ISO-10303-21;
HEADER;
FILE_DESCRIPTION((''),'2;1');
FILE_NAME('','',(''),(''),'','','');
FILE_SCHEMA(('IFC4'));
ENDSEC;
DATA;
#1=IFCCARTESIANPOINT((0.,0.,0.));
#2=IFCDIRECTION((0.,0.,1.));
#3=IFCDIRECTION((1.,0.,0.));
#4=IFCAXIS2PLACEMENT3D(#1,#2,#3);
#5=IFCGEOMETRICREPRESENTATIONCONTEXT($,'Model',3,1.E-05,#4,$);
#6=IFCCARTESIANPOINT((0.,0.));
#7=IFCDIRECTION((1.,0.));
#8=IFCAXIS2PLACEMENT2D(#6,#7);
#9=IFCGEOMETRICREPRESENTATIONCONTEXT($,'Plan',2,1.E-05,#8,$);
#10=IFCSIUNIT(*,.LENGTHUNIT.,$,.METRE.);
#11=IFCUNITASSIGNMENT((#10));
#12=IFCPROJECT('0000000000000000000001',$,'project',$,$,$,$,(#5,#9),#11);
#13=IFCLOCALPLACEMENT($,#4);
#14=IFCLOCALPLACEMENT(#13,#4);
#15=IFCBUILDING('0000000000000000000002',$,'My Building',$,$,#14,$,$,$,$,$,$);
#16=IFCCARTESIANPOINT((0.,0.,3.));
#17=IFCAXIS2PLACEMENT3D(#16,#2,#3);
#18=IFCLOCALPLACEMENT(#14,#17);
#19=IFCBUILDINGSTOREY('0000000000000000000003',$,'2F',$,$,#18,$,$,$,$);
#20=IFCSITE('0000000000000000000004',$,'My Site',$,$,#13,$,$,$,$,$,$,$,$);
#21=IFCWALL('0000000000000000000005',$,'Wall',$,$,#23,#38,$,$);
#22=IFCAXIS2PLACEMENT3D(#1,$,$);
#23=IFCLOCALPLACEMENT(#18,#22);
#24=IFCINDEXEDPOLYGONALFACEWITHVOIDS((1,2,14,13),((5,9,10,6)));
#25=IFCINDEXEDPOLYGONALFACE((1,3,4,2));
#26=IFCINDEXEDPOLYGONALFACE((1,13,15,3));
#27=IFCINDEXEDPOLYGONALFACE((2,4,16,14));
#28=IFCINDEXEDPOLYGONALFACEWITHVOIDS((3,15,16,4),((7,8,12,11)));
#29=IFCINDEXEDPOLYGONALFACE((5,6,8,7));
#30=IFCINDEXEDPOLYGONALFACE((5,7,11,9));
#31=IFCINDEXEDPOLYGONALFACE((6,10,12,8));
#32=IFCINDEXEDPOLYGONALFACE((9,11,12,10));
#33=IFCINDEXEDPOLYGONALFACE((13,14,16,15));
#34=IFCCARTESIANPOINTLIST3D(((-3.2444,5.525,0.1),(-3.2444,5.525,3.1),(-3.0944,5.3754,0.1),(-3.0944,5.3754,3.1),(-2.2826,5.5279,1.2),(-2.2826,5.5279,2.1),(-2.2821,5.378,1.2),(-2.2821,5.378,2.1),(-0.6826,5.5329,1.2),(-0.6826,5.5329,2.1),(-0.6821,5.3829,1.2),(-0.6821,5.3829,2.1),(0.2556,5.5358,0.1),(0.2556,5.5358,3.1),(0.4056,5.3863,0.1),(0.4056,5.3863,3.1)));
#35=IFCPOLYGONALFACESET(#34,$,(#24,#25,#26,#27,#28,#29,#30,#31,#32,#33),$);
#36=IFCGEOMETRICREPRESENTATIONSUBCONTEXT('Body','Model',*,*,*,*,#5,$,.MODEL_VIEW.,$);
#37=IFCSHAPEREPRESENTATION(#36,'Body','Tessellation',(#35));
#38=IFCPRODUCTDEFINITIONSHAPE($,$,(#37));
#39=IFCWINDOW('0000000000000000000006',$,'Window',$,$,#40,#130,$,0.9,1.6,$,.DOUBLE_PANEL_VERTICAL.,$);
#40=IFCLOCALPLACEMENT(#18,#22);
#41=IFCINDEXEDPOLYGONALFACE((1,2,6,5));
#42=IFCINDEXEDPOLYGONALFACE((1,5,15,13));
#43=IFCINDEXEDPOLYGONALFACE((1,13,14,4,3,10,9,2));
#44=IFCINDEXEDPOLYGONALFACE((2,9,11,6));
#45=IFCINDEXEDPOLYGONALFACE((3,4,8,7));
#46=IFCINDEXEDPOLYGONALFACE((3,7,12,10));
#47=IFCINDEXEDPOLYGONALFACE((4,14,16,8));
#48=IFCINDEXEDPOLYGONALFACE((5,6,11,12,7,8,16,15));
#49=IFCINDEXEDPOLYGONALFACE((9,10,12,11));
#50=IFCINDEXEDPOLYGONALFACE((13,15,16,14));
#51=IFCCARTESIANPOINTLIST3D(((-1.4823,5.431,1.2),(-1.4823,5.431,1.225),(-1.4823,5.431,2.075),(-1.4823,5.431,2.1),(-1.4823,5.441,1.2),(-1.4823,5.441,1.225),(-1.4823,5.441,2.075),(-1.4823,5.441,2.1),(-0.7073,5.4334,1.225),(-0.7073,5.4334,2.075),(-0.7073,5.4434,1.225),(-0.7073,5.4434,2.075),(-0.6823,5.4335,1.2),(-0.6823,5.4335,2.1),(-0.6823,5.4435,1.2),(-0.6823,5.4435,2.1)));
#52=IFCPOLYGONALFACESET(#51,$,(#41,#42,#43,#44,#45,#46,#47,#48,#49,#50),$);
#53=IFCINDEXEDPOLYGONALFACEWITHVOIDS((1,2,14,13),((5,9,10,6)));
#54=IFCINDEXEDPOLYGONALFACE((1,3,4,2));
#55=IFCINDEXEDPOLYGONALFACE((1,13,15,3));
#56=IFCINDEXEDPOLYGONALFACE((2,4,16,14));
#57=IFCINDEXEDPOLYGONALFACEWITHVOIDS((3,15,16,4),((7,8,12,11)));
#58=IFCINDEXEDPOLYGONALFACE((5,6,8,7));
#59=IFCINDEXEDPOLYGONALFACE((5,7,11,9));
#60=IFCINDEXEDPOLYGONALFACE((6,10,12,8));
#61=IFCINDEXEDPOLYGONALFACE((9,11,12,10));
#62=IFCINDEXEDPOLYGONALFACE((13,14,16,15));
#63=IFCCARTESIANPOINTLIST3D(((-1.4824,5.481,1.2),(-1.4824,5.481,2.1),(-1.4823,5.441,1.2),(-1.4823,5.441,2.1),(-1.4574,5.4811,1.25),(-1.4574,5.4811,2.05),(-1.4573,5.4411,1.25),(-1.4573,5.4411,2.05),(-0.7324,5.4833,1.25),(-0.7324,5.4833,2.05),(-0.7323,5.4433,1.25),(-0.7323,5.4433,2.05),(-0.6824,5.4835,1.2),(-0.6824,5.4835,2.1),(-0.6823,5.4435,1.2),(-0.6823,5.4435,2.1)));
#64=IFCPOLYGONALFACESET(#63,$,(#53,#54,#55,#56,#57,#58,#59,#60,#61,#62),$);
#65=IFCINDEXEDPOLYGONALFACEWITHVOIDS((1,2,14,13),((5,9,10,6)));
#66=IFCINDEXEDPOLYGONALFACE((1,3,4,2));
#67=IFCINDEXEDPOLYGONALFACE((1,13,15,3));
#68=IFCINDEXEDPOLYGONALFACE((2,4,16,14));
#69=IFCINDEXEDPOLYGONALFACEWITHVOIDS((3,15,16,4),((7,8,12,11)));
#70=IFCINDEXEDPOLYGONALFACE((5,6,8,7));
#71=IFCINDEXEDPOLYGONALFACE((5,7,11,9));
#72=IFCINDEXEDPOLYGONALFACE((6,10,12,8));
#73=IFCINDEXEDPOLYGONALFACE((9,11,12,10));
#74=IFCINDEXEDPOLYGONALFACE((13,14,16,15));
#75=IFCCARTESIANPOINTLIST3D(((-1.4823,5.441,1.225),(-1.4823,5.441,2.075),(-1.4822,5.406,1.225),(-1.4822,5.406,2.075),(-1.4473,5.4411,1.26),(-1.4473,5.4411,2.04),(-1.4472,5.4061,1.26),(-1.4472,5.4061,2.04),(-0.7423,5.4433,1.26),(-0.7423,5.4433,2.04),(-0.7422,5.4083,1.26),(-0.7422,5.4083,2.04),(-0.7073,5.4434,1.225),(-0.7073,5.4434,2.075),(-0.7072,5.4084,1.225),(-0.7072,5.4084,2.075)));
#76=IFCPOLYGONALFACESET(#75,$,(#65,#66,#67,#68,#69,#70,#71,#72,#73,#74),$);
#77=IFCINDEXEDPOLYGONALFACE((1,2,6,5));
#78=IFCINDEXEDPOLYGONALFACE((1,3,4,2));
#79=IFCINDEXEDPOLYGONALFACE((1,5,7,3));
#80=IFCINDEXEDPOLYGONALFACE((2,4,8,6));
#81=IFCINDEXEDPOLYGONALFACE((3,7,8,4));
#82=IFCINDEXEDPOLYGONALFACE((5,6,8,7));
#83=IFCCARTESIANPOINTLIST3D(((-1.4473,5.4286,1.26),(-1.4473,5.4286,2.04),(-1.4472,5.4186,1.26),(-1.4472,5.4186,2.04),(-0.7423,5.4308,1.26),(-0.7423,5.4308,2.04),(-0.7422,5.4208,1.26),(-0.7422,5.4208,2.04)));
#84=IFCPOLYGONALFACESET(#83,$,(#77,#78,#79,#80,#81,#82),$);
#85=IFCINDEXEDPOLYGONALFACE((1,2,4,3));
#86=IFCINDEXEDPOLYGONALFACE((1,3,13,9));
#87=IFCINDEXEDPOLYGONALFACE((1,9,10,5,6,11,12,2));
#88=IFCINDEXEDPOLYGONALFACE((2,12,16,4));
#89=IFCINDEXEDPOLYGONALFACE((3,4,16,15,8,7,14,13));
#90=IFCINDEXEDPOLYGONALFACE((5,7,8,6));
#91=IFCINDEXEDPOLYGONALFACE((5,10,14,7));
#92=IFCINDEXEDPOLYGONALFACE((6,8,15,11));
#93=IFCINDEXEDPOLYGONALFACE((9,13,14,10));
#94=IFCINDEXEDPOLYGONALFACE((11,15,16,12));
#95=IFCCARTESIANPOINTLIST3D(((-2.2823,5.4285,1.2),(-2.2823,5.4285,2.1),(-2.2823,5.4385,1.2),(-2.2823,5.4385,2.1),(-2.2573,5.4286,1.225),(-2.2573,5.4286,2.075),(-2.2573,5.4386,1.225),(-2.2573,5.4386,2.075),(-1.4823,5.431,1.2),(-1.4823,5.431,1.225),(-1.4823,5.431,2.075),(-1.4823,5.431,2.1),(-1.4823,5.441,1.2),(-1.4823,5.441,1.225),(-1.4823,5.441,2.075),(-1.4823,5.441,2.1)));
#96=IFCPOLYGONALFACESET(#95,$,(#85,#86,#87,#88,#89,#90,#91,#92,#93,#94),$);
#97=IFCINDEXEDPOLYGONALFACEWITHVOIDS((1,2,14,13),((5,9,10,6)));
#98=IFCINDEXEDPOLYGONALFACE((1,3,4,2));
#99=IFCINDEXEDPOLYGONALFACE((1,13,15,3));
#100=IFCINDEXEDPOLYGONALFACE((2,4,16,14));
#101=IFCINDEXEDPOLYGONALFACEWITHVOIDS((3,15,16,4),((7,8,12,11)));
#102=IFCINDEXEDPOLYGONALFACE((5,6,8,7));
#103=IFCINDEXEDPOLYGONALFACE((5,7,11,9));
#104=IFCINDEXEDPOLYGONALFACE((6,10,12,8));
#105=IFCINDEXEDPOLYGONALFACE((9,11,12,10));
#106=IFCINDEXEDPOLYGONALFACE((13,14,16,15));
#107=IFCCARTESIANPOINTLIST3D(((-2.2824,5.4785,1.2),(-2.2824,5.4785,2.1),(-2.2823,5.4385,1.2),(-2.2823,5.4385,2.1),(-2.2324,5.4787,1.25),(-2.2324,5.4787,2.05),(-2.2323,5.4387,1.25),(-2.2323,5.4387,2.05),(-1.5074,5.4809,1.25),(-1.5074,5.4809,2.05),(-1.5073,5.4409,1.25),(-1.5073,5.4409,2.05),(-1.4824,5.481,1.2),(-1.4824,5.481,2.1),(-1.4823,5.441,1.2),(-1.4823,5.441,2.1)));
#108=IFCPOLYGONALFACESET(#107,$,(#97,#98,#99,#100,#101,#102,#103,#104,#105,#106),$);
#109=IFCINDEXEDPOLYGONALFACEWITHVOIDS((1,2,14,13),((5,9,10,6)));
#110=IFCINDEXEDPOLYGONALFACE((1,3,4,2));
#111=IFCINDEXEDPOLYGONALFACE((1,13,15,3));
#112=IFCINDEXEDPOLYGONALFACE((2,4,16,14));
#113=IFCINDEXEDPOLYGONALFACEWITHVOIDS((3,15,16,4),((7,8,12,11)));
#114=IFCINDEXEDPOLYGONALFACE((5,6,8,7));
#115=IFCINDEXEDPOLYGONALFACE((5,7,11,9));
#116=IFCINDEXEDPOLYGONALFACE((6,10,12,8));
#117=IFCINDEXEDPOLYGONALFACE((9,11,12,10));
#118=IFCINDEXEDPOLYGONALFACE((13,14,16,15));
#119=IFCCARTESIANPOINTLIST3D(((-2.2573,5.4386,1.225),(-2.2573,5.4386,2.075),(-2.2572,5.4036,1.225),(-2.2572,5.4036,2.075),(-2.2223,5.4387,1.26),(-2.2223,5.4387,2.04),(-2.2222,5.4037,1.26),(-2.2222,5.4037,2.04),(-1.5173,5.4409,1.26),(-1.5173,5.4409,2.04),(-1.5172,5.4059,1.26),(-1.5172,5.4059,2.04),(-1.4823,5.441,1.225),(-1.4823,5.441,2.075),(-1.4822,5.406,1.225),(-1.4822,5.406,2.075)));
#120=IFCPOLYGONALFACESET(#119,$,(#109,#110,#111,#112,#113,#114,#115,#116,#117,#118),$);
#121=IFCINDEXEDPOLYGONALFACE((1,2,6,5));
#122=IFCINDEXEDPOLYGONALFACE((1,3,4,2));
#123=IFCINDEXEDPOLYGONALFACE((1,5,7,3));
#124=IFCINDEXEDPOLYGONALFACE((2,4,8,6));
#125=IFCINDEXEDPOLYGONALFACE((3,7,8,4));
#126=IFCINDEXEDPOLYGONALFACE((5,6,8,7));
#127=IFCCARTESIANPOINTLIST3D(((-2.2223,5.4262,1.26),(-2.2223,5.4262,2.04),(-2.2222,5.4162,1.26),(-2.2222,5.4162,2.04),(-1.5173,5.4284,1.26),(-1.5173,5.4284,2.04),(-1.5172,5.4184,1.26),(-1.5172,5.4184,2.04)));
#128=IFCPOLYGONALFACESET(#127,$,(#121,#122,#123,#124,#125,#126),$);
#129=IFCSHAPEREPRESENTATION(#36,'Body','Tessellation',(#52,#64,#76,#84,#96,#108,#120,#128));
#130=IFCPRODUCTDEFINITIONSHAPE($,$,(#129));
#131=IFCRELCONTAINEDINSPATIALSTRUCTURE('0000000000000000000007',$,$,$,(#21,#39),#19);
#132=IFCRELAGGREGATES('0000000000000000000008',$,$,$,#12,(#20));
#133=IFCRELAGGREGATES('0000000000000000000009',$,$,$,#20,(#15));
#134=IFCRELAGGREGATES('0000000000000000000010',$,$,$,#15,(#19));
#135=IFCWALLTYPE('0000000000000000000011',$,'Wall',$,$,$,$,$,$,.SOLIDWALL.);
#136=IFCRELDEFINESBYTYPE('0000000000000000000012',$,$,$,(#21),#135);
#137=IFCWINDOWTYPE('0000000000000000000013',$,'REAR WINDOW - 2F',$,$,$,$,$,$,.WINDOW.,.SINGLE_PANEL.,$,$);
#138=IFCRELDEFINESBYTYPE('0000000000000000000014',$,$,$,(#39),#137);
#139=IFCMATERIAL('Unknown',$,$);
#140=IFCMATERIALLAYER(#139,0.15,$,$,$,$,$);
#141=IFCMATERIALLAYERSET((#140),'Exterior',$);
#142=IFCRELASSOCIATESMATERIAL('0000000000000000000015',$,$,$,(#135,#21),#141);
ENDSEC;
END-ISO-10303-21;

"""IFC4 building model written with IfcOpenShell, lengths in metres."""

from ifc_helpers import new_model, entity, si_unit, frame, origin_with_axes, origin_2d_with_axis, place, context, subcontext, project, spatial, line, indexed_curve, outline, extrude, shape, source, transform, mapped, material, layer, layer_set, layer_usage, type_object, type_shapes, element, fill, save


model = new_model("IFC4")

# Units and contexts
model_context = context("Model", 3, precision=1e-05, world=origin_with_axes())
plan_context = context("Plan", 2, precision=1e-05, world=origin_2d_with_axis())
body_context_1 = subcontext(model_context, "Body", "Model", "MODEL_VIEW")
body_context_2 = subcontext(plan_context, "Body", "Plan", "PLAN_VIEW")
ifc_project = project(units=[si_unit("LENGTHUNIT", "METRE")], contexts=[model_context, plan_context])

# Site, building, storey
site_placement = place(None, origin_with_axes())
site = spatial("IfcSite", under=ifc_project, at=site_placement, Name="My Site")
building_placement = place(site_placement, origin_with_axes())
building = spatial("IfcBuilding", under=site, at=building_placement, Name="My Building")
storey_placement = place(building_placement, frame((0.0, 0.0, 3.0), z_axis=(0.0, 0.0, 1.0), x_axis=(1.0, 0.0, 0.0)))
storey = spatial("IfcBuildingStorey", under=building, at=storey_placement, Name="2F")

# Shared definitions
ifc_material = material(Name="Unknown")

# Shared definitions
ifc_layer_1 = layer(ifc_material, 0.15)
ifc_layer_set_1 = layer_set([ifc_layer_1], Name="Exterior")
wall_type_1 = type_object("IfcWallType", Name="Wall", PredefinedType="SOLIDWALL", material=ifc_layer_set_1)

# Wall, opening, window
ifc_layer_usage_1 = layer_usage(ifc_layer_set_1, "AXIS2", "POSITIVE", 0.0)
wall_1_placement = place(storey_placement, frame((0.2556, 5.5358, 0.1), z_axis=(0.0, 0.0, 1.0), x_axis=(-0.999995, -0.003097, 0.0)))
wall_1 = element("IfcWall", 1, at=wall_1_placement, inside=storey, type_object=wall_type_1, material=ifc_layer_usage_1, Name="Wall", context=body_context_1, shape_type="SweptSolid", body=[
    extrude(outline(indexed_curve([(0.0, 0.0), (-0.1495, 0.15), (3.3505, 0.15), (3.5, 0.0)], segments=[line(1, 2, 3, 4, 1)])), origin_with_axes(), (0.0, 0.0, 1.0), 3.0),
])
shared_shape_1 = source(origin_with_axes(), body_context_1, "Body", "SweptSolid", [
    extrude(outline(indexed_curve([(0.0, 0.0), (1.6, 0.0), (1.6, 0.9), (0.0, 0.9)], segments=[line(1, 2, 3, 4, 1)])), frame((0.0, -0.6, 0.0), z_axis=(0.0, -1.0, 0.0), x_axis=(1.0, 0.0, 0.0)), (0.0, 0.0, -1.0), 1.2),
])
opening_1_placement = place(wall_1_placement, frame((0.9382, -0.0006, 1.1), z_axis=(0.0, 0.0, 1.0), x_axis=(1.0, 0.0, 0.0)))
opening_1 = element("IfcOpeningElement", 2, at=opening_1_placement, cuts=wall_1, PredefinedType="OPENING", context=body_context_1, shape_type="MappedRepresentation", body=[
    mapped(shared_shape_1, transform((0.0, 0.0, 0.0), x_axis=(1.0, 0.0, 0.0), y_axis=(0.0, 1.0, 0.0), z_axis=(0.0, 0.0, 1.0), scale=1.0)),
])
window_type_1 = type_object("IfcWindowType", Name="REAR WINDOW - 2F", PartitioningType="SINGLE_PANEL", PredefinedType="WINDOW")
shared_shape_2 = source(origin_with_axes(), body_context_1, "Body", "SweptSolid", [
    extrude(outline(indexed_curve([(0.8, 0.0), (0.0, 0.0), (0.0, 0.9), (0.8, 0.9), (0.8, 0.875), (0.025, 0.875), (0.025, 0.025), (0.8, 0.025)], segments=[line(1, 2, 3, 4, 5, 6, 7, 8, 1)])), frame((0.0, 0.09, 0.0), z_axis=(0.0, -1.0, 0.0), x_axis=(1.0, 0.0, 0.0)), (0.0, 0.0, -1.0), 0.01),
    extrude(outline(indexed_curve([(0.0, 0.0), (0.8, 0.0), (0.8, 0.9), (0.0, 0.9)], segments=[line(1, 2, 3, 4, 1)]), holes=[indexed_curve([(0.05, 0.05), (0.775, 0.05), (0.775, 0.85), (0.05, 0.85)], segments=[line(1, 2, 3, 4, 1)])]), frame((0.0, 0.05, 0.0), z_axis=(0.0, -1.0, 0.0), x_axis=(1.0, 0.0, 0.0)), (0.0, 0.0, -1.0), 0.04),
    extrude(outline(indexed_curve([(0.0, 0.0), (0.775, 0.0), (0.775, 0.85), (0.0, 0.85)], segments=[line(1, 2, 3, 4, 1)]), holes=[indexed_curve([(0.035, 0.035), (0.74, 0.035), (0.74, 0.815), (0.035, 0.815)], segments=[line(1, 2, 3, 4, 1)])]), frame((0.025, 0.09, 0.025), z_axis=(0.0, -1.0, 0.0), x_axis=(1.0, 0.0, 0.0)), (0.0, 0.0, -1.0), 0.035),
    extrude(outline(indexed_curve([(0.035, 0.035), (0.74, 0.035), (0.74, 0.815), (0.035, 0.815)], segments=[line(1, 2, 3, 4, 1)])), frame((0.025, 0.1025, 0.025), z_axis=(0.0, -1.0, 0.0), x_axis=(1.0, 0.0, 0.0)), (0.0, 0.0, -1.0), 0.01),
    extrude(outline(indexed_curve([(0.0, 0.9), (0.8, 0.9), (0.8, 0.0), (0.0, 0.0), (0.0, 0.025), (0.775, 0.025), (0.775, 0.875), (0.0, 0.875)], segments=[line(1, 2, 3, 4, 5, 6, 7, 8, 1)])), frame((0.8, 0.09, 0.0), z_axis=(0.0, -1.0, 0.0), x_axis=(1.0, 0.0, 0.0)), (0.0, 0.0, -1.0), 0.01),
    extrude(outline(indexed_curve([(0.0, 0.0), (0.8, 0.0), (0.8, 0.9), (0.0, 0.9)], segments=[line(1, 2, 3, 4, 1)]), holes=[indexed_curve([(0.025, 0.05), (0.75, 0.05), (0.75, 0.85), (0.025, 0.85)], segments=[line(1, 2, 3, 4, 1)])]), frame((0.8, 0.05, 0.0), z_axis=(0.0, -1.0, 0.0), x_axis=(1.0, 0.0, 0.0)), (0.0, 0.0, -1.0), 0.04),
    extrude(outline(indexed_curve([(0.0, 0.0), (0.775, 0.0), (0.775, 0.85), (0.0, 0.85)], segments=[line(1, 2, 3, 4, 1)]), holes=[indexed_curve([(0.035, 0.035), (0.74, 0.035), (0.74, 0.815), (0.035, 0.815)], segments=[line(1, 2, 3, 4, 1)])]), frame((0.8, 0.09, 0.025), z_axis=(0.0, -1.0, 0.0), x_axis=(1.0, 0.0, 0.0)), (0.0, 0.0, -1.0), 0.035),
    extrude(outline(indexed_curve([(0.035, 0.035), (0.74, 0.035), (0.74, 0.815), (0.035, 0.815)], segments=[line(1, 2, 3, 4, 1)])), frame((0.8, 0.1025, 0.025), z_axis=(0.0, -1.0, 0.0), x_axis=(1.0, 0.0, 0.0)), (0.0, 0.0, -1.0), 0.01),
])
shared_shape_3 = source(origin_with_axes(), body_context_2, "Body", "Curve2D", [
    entity("IfcIndexedPolyCurve", entity("IfcCartesianPointList2D", [[0.05, 0.05], [0.775, 0.05]])),
    entity("IfcIndexedPolyCurve", entity("IfcCartesianPointList2D", [[0.0, 0.1], [0.025, 0.1], [0.025, 0.09], [0.05, 0.09], [0.05, 0.05], [0.0, 0.05]]), [entity("IfcLineIndex", [1, 2, 3, 4, 5, 6, 1])]),
    entity("IfcIndexedPolyCurve", entity("IfcCartesianPointList2D", [[0.8, 0.1], [0.8, 0.1], [0.8, 0.09], [0.775, 0.09], [0.775, 0.05], [0.8, 0.05]])),
    entity("IfcIndexedPolyCurve", entity("IfcCartesianPointList2D", [[0.025, 0.09], [0.06, 0.09], [0.06, 0.125], [0.025, 0.125]]), [entity("IfcLineIndex", [1, 2, 3, 4, 1])]),
    entity("IfcIndexedPolyCurve", entity("IfcCartesianPointList2D", [[0.8, 0.09], [0.765, 0.09], [0.765, 0.125], [0.8, 0.125]]), [entity("IfcLineIndex", [1, 2, 3, 4, 1])]),
    entity("IfcIndexedPolyCurve", entity("IfcCartesianPointList2D", [[0.06, 0.09], [0.765, 0.09]])),
    entity("IfcIndexedPolyCurve", entity("IfcCartesianPointList2D", [[0.06, 0.125], [0.765, 0.125]])),
    entity("IfcIndexedPolyCurve", entity("IfcCartesianPointList2D", [[0.06, 0.1075], [0.765, 0.1075]])),
    entity("IfcIndexedPolyCurve", entity("IfcCartesianPointList2D", [[0.825, 0.05], [1.55, 0.05]])),
    entity("IfcIndexedPolyCurve", entity("IfcCartesianPointList2D", [[0.8, 0.1], [0.8, 0.1], [0.8, 0.09], [0.825, 0.09], [0.825, 0.05], [0.8, 0.05]])),
    entity("IfcIndexedPolyCurve", entity("IfcCartesianPointList2D", [[1.6, 0.1], [1.575, 0.1], [1.575, 0.09], [1.55, 0.09], [1.55, 0.05], [1.6, 0.05]]), [entity("IfcLineIndex", [1, 2, 3, 4, 5, 6, 1])]),
    entity("IfcIndexedPolyCurve", entity("IfcCartesianPointList2D", [[0.8, 0.09], [0.835, 0.09], [0.835, 0.125], [0.8, 0.125]]), [entity("IfcLineIndex", [1, 2, 3, 4, 1])]),
    entity("IfcIndexedPolyCurve", entity("IfcCartesianPointList2D", [[1.575, 0.09], [1.54, 0.09], [1.54, 0.125], [1.575, 0.125]]), [entity("IfcLineIndex", [1, 2, 3, 4, 1])]),
    entity("IfcIndexedPolyCurve", entity("IfcCartesianPointList2D", [[0.835, 0.09], [1.54, 0.09]])),
    entity("IfcIndexedPolyCurve", entity("IfcCartesianPointList2D", [[0.835, 0.125], [1.54, 0.125]])),
    entity("IfcIndexedPolyCurve", entity("IfcCartesianPointList2D", [[0.835, 0.1075], [1.54, 0.1075]])),
])
type_shapes(window_type_1, [shared_shape_2, shared_shape_3])
window_1_placement = place(opening_1_placement, frame((0.0, 0.0, 0.0), z_axis=(0.0, 0.0, 1.0), x_axis=(1.0, 0.0, 0.0)))
window_1 = element("IfcWindow", 3, at=window_1_placement, inside=storey, type_object=window_type_1, Name="Window", OverallHeight=0.9, OverallWidth=1.6, PartitioningType="DOUBLE_PANEL_VERTICAL", shapes=[
    shape(body_context_1, "Body", "MappedRepresentation", [mapped(shared_shape_2, transform((0.0, 0.0, 0.0), x_axis=(1.0, 0.0, 0.0), y_axis=(0.0, 1.0, 0.0), z_axis=(0.0, 0.0, 1.0), scale=1.0))]),
    shape(body_context_2, "Body", "MappedRepresentation", [mapped(shared_shape_3, transform((0.0, 0.0, 0.0), x_axis=(1.0, 0.0, 0.0), y_axis=(0.0, 1.0, 0.0), z_axis=(0.0, 0.0, 1.0), scale=1.0))]),
])
fill(opening_1, window_1)

save(model, "model.ifc")
